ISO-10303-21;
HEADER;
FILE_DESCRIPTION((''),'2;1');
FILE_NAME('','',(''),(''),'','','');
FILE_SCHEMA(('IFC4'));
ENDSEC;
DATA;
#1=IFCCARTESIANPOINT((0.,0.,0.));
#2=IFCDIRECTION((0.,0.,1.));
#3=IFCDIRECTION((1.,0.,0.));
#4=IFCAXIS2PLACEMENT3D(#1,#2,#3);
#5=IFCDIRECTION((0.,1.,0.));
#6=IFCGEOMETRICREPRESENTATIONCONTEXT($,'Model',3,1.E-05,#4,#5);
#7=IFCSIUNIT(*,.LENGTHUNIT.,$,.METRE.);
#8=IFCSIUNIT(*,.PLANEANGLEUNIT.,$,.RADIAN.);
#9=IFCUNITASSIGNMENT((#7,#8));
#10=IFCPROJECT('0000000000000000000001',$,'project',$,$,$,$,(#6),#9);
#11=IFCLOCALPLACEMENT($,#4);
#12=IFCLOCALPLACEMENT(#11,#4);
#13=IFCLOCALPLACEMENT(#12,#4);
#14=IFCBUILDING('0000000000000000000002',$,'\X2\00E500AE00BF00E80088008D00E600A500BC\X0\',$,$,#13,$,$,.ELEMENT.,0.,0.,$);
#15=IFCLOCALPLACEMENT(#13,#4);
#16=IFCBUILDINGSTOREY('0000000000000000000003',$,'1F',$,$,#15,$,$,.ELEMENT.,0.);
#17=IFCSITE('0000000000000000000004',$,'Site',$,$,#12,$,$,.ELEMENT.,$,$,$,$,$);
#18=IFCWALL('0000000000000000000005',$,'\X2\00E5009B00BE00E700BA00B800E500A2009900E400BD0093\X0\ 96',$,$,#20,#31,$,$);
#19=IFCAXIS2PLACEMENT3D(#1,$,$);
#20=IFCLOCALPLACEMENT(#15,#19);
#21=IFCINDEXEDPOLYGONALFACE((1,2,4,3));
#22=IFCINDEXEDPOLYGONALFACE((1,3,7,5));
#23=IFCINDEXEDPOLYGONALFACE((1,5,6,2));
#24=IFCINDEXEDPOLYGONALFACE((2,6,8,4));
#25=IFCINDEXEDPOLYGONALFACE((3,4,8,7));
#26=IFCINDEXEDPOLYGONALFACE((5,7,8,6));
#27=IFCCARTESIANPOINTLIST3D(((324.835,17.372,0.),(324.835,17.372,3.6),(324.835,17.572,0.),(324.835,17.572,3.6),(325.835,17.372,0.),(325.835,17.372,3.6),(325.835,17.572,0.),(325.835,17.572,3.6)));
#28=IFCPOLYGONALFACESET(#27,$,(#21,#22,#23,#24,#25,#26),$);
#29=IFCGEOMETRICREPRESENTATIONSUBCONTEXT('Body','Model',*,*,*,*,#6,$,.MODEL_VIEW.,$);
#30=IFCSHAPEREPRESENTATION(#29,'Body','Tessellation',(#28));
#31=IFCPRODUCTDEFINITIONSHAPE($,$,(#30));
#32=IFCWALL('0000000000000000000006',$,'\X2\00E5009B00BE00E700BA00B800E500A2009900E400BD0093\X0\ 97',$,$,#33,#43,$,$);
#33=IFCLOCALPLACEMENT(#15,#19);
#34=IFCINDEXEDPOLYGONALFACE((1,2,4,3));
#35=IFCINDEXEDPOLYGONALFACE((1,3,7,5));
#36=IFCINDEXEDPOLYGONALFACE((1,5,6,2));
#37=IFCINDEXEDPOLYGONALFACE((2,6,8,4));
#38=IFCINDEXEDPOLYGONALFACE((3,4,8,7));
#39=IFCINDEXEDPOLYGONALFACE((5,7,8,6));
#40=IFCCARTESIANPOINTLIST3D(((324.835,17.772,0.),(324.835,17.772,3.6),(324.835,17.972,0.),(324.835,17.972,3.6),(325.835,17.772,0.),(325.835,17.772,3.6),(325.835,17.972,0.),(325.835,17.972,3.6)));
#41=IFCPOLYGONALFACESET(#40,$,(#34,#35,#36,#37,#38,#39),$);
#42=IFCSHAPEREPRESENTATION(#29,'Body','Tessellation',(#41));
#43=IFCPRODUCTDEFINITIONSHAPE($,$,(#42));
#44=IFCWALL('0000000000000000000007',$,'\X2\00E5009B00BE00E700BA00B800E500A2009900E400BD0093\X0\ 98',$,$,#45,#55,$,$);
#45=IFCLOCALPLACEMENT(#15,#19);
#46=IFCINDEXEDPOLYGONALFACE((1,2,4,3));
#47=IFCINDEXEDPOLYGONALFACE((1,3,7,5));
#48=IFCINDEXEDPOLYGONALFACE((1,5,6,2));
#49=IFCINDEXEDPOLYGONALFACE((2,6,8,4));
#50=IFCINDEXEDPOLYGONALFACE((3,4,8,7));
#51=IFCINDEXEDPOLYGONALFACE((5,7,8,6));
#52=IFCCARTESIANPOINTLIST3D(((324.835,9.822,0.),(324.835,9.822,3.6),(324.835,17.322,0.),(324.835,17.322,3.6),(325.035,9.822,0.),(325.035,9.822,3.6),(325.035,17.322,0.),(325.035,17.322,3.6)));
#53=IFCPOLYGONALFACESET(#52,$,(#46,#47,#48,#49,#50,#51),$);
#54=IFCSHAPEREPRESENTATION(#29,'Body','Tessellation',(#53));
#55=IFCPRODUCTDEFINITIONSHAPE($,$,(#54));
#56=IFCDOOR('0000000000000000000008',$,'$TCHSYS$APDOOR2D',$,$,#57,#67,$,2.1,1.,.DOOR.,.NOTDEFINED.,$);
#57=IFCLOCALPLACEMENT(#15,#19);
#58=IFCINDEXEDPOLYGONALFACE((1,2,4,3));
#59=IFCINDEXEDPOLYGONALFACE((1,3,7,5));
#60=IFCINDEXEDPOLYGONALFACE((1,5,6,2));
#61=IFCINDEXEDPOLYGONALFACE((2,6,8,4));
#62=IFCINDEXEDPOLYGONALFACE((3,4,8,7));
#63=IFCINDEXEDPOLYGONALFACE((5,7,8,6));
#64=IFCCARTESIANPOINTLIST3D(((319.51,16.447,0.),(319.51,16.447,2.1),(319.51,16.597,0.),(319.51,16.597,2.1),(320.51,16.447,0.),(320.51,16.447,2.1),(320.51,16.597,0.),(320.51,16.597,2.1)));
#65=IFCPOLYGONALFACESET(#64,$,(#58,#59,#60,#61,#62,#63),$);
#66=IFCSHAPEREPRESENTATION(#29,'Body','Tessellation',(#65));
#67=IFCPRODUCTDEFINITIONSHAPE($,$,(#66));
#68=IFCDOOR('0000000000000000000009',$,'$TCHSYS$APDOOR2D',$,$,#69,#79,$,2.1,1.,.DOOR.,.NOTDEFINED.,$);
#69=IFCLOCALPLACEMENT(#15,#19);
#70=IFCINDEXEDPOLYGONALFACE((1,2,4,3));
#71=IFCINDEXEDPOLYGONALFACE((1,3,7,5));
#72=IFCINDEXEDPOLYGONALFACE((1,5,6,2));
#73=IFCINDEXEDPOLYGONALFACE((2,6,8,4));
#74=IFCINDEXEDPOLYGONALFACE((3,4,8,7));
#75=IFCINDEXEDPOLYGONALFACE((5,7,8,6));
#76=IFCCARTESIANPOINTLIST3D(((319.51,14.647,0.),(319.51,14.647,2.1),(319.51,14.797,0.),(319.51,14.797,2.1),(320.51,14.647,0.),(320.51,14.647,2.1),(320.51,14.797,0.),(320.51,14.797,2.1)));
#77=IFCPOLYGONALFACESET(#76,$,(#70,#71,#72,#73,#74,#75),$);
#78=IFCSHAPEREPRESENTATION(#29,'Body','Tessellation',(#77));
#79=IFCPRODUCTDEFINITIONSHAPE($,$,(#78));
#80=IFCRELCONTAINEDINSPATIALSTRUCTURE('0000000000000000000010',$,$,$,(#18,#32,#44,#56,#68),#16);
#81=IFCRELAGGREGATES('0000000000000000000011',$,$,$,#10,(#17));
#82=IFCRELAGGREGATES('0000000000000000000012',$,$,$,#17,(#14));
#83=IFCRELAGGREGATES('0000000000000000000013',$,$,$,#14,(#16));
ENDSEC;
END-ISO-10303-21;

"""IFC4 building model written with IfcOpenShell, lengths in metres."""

from ifc_helpers import new_model, si_unit, direction, frame, frame_2d, origin_with_axes, place, context, subcontext, project, spatial, rectangle, extrude, element, save


model = new_model("IFC4")

# Units and contexts
model_context = context("Model", 3, precision=1e-05, world=origin_with_axes(), true_north=direction((0.0, 1.0, 0.0)))
body_context = subcontext(model_context, "Body", "Model", "MODEL_VIEW")
ifc_project = project(units=[si_unit("LENGTHUNIT", "METRE"), si_unit("PLANEANGLEUNIT", "RADIAN")], contexts=[model_context])

# Site, building, storey
placement = place(None, origin_with_axes())
site_placement = place(placement, origin_with_axes())
site = spatial("IfcSite", under=ifc_project, at=site_placement, Name="Site", CompositionType="ELEMENT")
building_placement = place(site_placement, origin_with_axes())
building = spatial("IfcBuilding", under=site, at=building_placement, Name="å®¿è\u0088\u008dæ¥¼", CompositionType="ELEMENT", ElevationOfRefHeight=0.0, ElevationOfTerrain=0.0)
storey_placement = place(building_placement, origin_with_axes())
storey = spatial("IfcBuildingStorey", under=building, at=storey_placement, Name="1F", CompositionType="ELEMENT", Elevation=0.0)

# Walls
for number, where, z_axis, x_axis, name in (
    (1, (325.335, 17.472, 0.0), (0.0, 0.0, 1.0), (1.0, 0.0, 0.0), "å\u009b¾çº¸å¢\u0099ä½\u0093 96"),
    (2, (325.335, 17.872, 0.0), (0.0, 0.0, 1.0), (1.0, 0.0, 0.0), "å\u009b¾çº¸å¢\u0099ä½\u0093 97"),
):
    element("IfcWall", number, at=place(storey_placement, frame(where, z_axis=z_axis, x_axis=x_axis)), inside=storey, Name=name, context=body_context, shape_type="SweptSolid", body=[
        extrude(rectangle(XDim=1.0, YDim=0.2, at=frame_2d((0.0, 0.0), x_axis=(1.0, 0.0, 0.0))), frame((0.0, 0.0, 0.0), z_axis=(0.0, 0.0, 1.0)), (0.0, 0.0, 1.0), 3.6),
    ])
wall_1_placement = place(storey_placement, frame((324.935, 13.572, 0.0), z_axis=(0.0, 0.0, 1.0), x_axis=(0.0, 1.0, 0.0)))
element("IfcWall", 3, at=wall_1_placement, inside=storey, Name="å\u009b¾çº¸å¢\u0099ä½\u0093 98", context=body_context, shape_type="SweptSolid", body=[
    extrude(rectangle(XDim=7.5, YDim=0.2, at=frame_2d((0.0, 0.0), x_axis=(1.0, 0.0, 0.0))), frame((0.0, 0.0, 0.0), z_axis=(0.0, 0.0, 1.0)), (0.0, 0.0, 1.0), 3.6),
])

# Doors
for number, where, z_axis, x_axis, name in (
    (4, (320.01, 16.522, 0.0), (0.0, 0.0, 1.0), (1.0, 0.0, 0.0), "$TCHSYS$APDOOR2D"),
    (5, (320.01, 14.722, 0.0), (0.0, 0.0, 1.0), (1.0, 0.0, 0.0), "$TCHSYS$APDOOR2D"),
):
    element("IfcDoor", number, at=place(storey_placement, frame(where, z_axis=z_axis, x_axis=x_axis)), inside=storey, Name=name, OperationType="NOTDEFINED", OverallHeight=2.1, OverallWidth=1.0, PredefinedType="DOOR", context=body_context, shape_type="SweptSolid", body=[
        extrude(rectangle(XDim=1.0, YDim=0.15, at=frame_2d((0.0, 0.0), x_axis=(1.0, 0.0, 0.0))), frame((0.0, 0.0, 0.0), z_axis=(0.0, 0.0, 1.0)), (0.0, 0.0, 1.0), 2.1),
    ])

save(model, "model.ifc")
